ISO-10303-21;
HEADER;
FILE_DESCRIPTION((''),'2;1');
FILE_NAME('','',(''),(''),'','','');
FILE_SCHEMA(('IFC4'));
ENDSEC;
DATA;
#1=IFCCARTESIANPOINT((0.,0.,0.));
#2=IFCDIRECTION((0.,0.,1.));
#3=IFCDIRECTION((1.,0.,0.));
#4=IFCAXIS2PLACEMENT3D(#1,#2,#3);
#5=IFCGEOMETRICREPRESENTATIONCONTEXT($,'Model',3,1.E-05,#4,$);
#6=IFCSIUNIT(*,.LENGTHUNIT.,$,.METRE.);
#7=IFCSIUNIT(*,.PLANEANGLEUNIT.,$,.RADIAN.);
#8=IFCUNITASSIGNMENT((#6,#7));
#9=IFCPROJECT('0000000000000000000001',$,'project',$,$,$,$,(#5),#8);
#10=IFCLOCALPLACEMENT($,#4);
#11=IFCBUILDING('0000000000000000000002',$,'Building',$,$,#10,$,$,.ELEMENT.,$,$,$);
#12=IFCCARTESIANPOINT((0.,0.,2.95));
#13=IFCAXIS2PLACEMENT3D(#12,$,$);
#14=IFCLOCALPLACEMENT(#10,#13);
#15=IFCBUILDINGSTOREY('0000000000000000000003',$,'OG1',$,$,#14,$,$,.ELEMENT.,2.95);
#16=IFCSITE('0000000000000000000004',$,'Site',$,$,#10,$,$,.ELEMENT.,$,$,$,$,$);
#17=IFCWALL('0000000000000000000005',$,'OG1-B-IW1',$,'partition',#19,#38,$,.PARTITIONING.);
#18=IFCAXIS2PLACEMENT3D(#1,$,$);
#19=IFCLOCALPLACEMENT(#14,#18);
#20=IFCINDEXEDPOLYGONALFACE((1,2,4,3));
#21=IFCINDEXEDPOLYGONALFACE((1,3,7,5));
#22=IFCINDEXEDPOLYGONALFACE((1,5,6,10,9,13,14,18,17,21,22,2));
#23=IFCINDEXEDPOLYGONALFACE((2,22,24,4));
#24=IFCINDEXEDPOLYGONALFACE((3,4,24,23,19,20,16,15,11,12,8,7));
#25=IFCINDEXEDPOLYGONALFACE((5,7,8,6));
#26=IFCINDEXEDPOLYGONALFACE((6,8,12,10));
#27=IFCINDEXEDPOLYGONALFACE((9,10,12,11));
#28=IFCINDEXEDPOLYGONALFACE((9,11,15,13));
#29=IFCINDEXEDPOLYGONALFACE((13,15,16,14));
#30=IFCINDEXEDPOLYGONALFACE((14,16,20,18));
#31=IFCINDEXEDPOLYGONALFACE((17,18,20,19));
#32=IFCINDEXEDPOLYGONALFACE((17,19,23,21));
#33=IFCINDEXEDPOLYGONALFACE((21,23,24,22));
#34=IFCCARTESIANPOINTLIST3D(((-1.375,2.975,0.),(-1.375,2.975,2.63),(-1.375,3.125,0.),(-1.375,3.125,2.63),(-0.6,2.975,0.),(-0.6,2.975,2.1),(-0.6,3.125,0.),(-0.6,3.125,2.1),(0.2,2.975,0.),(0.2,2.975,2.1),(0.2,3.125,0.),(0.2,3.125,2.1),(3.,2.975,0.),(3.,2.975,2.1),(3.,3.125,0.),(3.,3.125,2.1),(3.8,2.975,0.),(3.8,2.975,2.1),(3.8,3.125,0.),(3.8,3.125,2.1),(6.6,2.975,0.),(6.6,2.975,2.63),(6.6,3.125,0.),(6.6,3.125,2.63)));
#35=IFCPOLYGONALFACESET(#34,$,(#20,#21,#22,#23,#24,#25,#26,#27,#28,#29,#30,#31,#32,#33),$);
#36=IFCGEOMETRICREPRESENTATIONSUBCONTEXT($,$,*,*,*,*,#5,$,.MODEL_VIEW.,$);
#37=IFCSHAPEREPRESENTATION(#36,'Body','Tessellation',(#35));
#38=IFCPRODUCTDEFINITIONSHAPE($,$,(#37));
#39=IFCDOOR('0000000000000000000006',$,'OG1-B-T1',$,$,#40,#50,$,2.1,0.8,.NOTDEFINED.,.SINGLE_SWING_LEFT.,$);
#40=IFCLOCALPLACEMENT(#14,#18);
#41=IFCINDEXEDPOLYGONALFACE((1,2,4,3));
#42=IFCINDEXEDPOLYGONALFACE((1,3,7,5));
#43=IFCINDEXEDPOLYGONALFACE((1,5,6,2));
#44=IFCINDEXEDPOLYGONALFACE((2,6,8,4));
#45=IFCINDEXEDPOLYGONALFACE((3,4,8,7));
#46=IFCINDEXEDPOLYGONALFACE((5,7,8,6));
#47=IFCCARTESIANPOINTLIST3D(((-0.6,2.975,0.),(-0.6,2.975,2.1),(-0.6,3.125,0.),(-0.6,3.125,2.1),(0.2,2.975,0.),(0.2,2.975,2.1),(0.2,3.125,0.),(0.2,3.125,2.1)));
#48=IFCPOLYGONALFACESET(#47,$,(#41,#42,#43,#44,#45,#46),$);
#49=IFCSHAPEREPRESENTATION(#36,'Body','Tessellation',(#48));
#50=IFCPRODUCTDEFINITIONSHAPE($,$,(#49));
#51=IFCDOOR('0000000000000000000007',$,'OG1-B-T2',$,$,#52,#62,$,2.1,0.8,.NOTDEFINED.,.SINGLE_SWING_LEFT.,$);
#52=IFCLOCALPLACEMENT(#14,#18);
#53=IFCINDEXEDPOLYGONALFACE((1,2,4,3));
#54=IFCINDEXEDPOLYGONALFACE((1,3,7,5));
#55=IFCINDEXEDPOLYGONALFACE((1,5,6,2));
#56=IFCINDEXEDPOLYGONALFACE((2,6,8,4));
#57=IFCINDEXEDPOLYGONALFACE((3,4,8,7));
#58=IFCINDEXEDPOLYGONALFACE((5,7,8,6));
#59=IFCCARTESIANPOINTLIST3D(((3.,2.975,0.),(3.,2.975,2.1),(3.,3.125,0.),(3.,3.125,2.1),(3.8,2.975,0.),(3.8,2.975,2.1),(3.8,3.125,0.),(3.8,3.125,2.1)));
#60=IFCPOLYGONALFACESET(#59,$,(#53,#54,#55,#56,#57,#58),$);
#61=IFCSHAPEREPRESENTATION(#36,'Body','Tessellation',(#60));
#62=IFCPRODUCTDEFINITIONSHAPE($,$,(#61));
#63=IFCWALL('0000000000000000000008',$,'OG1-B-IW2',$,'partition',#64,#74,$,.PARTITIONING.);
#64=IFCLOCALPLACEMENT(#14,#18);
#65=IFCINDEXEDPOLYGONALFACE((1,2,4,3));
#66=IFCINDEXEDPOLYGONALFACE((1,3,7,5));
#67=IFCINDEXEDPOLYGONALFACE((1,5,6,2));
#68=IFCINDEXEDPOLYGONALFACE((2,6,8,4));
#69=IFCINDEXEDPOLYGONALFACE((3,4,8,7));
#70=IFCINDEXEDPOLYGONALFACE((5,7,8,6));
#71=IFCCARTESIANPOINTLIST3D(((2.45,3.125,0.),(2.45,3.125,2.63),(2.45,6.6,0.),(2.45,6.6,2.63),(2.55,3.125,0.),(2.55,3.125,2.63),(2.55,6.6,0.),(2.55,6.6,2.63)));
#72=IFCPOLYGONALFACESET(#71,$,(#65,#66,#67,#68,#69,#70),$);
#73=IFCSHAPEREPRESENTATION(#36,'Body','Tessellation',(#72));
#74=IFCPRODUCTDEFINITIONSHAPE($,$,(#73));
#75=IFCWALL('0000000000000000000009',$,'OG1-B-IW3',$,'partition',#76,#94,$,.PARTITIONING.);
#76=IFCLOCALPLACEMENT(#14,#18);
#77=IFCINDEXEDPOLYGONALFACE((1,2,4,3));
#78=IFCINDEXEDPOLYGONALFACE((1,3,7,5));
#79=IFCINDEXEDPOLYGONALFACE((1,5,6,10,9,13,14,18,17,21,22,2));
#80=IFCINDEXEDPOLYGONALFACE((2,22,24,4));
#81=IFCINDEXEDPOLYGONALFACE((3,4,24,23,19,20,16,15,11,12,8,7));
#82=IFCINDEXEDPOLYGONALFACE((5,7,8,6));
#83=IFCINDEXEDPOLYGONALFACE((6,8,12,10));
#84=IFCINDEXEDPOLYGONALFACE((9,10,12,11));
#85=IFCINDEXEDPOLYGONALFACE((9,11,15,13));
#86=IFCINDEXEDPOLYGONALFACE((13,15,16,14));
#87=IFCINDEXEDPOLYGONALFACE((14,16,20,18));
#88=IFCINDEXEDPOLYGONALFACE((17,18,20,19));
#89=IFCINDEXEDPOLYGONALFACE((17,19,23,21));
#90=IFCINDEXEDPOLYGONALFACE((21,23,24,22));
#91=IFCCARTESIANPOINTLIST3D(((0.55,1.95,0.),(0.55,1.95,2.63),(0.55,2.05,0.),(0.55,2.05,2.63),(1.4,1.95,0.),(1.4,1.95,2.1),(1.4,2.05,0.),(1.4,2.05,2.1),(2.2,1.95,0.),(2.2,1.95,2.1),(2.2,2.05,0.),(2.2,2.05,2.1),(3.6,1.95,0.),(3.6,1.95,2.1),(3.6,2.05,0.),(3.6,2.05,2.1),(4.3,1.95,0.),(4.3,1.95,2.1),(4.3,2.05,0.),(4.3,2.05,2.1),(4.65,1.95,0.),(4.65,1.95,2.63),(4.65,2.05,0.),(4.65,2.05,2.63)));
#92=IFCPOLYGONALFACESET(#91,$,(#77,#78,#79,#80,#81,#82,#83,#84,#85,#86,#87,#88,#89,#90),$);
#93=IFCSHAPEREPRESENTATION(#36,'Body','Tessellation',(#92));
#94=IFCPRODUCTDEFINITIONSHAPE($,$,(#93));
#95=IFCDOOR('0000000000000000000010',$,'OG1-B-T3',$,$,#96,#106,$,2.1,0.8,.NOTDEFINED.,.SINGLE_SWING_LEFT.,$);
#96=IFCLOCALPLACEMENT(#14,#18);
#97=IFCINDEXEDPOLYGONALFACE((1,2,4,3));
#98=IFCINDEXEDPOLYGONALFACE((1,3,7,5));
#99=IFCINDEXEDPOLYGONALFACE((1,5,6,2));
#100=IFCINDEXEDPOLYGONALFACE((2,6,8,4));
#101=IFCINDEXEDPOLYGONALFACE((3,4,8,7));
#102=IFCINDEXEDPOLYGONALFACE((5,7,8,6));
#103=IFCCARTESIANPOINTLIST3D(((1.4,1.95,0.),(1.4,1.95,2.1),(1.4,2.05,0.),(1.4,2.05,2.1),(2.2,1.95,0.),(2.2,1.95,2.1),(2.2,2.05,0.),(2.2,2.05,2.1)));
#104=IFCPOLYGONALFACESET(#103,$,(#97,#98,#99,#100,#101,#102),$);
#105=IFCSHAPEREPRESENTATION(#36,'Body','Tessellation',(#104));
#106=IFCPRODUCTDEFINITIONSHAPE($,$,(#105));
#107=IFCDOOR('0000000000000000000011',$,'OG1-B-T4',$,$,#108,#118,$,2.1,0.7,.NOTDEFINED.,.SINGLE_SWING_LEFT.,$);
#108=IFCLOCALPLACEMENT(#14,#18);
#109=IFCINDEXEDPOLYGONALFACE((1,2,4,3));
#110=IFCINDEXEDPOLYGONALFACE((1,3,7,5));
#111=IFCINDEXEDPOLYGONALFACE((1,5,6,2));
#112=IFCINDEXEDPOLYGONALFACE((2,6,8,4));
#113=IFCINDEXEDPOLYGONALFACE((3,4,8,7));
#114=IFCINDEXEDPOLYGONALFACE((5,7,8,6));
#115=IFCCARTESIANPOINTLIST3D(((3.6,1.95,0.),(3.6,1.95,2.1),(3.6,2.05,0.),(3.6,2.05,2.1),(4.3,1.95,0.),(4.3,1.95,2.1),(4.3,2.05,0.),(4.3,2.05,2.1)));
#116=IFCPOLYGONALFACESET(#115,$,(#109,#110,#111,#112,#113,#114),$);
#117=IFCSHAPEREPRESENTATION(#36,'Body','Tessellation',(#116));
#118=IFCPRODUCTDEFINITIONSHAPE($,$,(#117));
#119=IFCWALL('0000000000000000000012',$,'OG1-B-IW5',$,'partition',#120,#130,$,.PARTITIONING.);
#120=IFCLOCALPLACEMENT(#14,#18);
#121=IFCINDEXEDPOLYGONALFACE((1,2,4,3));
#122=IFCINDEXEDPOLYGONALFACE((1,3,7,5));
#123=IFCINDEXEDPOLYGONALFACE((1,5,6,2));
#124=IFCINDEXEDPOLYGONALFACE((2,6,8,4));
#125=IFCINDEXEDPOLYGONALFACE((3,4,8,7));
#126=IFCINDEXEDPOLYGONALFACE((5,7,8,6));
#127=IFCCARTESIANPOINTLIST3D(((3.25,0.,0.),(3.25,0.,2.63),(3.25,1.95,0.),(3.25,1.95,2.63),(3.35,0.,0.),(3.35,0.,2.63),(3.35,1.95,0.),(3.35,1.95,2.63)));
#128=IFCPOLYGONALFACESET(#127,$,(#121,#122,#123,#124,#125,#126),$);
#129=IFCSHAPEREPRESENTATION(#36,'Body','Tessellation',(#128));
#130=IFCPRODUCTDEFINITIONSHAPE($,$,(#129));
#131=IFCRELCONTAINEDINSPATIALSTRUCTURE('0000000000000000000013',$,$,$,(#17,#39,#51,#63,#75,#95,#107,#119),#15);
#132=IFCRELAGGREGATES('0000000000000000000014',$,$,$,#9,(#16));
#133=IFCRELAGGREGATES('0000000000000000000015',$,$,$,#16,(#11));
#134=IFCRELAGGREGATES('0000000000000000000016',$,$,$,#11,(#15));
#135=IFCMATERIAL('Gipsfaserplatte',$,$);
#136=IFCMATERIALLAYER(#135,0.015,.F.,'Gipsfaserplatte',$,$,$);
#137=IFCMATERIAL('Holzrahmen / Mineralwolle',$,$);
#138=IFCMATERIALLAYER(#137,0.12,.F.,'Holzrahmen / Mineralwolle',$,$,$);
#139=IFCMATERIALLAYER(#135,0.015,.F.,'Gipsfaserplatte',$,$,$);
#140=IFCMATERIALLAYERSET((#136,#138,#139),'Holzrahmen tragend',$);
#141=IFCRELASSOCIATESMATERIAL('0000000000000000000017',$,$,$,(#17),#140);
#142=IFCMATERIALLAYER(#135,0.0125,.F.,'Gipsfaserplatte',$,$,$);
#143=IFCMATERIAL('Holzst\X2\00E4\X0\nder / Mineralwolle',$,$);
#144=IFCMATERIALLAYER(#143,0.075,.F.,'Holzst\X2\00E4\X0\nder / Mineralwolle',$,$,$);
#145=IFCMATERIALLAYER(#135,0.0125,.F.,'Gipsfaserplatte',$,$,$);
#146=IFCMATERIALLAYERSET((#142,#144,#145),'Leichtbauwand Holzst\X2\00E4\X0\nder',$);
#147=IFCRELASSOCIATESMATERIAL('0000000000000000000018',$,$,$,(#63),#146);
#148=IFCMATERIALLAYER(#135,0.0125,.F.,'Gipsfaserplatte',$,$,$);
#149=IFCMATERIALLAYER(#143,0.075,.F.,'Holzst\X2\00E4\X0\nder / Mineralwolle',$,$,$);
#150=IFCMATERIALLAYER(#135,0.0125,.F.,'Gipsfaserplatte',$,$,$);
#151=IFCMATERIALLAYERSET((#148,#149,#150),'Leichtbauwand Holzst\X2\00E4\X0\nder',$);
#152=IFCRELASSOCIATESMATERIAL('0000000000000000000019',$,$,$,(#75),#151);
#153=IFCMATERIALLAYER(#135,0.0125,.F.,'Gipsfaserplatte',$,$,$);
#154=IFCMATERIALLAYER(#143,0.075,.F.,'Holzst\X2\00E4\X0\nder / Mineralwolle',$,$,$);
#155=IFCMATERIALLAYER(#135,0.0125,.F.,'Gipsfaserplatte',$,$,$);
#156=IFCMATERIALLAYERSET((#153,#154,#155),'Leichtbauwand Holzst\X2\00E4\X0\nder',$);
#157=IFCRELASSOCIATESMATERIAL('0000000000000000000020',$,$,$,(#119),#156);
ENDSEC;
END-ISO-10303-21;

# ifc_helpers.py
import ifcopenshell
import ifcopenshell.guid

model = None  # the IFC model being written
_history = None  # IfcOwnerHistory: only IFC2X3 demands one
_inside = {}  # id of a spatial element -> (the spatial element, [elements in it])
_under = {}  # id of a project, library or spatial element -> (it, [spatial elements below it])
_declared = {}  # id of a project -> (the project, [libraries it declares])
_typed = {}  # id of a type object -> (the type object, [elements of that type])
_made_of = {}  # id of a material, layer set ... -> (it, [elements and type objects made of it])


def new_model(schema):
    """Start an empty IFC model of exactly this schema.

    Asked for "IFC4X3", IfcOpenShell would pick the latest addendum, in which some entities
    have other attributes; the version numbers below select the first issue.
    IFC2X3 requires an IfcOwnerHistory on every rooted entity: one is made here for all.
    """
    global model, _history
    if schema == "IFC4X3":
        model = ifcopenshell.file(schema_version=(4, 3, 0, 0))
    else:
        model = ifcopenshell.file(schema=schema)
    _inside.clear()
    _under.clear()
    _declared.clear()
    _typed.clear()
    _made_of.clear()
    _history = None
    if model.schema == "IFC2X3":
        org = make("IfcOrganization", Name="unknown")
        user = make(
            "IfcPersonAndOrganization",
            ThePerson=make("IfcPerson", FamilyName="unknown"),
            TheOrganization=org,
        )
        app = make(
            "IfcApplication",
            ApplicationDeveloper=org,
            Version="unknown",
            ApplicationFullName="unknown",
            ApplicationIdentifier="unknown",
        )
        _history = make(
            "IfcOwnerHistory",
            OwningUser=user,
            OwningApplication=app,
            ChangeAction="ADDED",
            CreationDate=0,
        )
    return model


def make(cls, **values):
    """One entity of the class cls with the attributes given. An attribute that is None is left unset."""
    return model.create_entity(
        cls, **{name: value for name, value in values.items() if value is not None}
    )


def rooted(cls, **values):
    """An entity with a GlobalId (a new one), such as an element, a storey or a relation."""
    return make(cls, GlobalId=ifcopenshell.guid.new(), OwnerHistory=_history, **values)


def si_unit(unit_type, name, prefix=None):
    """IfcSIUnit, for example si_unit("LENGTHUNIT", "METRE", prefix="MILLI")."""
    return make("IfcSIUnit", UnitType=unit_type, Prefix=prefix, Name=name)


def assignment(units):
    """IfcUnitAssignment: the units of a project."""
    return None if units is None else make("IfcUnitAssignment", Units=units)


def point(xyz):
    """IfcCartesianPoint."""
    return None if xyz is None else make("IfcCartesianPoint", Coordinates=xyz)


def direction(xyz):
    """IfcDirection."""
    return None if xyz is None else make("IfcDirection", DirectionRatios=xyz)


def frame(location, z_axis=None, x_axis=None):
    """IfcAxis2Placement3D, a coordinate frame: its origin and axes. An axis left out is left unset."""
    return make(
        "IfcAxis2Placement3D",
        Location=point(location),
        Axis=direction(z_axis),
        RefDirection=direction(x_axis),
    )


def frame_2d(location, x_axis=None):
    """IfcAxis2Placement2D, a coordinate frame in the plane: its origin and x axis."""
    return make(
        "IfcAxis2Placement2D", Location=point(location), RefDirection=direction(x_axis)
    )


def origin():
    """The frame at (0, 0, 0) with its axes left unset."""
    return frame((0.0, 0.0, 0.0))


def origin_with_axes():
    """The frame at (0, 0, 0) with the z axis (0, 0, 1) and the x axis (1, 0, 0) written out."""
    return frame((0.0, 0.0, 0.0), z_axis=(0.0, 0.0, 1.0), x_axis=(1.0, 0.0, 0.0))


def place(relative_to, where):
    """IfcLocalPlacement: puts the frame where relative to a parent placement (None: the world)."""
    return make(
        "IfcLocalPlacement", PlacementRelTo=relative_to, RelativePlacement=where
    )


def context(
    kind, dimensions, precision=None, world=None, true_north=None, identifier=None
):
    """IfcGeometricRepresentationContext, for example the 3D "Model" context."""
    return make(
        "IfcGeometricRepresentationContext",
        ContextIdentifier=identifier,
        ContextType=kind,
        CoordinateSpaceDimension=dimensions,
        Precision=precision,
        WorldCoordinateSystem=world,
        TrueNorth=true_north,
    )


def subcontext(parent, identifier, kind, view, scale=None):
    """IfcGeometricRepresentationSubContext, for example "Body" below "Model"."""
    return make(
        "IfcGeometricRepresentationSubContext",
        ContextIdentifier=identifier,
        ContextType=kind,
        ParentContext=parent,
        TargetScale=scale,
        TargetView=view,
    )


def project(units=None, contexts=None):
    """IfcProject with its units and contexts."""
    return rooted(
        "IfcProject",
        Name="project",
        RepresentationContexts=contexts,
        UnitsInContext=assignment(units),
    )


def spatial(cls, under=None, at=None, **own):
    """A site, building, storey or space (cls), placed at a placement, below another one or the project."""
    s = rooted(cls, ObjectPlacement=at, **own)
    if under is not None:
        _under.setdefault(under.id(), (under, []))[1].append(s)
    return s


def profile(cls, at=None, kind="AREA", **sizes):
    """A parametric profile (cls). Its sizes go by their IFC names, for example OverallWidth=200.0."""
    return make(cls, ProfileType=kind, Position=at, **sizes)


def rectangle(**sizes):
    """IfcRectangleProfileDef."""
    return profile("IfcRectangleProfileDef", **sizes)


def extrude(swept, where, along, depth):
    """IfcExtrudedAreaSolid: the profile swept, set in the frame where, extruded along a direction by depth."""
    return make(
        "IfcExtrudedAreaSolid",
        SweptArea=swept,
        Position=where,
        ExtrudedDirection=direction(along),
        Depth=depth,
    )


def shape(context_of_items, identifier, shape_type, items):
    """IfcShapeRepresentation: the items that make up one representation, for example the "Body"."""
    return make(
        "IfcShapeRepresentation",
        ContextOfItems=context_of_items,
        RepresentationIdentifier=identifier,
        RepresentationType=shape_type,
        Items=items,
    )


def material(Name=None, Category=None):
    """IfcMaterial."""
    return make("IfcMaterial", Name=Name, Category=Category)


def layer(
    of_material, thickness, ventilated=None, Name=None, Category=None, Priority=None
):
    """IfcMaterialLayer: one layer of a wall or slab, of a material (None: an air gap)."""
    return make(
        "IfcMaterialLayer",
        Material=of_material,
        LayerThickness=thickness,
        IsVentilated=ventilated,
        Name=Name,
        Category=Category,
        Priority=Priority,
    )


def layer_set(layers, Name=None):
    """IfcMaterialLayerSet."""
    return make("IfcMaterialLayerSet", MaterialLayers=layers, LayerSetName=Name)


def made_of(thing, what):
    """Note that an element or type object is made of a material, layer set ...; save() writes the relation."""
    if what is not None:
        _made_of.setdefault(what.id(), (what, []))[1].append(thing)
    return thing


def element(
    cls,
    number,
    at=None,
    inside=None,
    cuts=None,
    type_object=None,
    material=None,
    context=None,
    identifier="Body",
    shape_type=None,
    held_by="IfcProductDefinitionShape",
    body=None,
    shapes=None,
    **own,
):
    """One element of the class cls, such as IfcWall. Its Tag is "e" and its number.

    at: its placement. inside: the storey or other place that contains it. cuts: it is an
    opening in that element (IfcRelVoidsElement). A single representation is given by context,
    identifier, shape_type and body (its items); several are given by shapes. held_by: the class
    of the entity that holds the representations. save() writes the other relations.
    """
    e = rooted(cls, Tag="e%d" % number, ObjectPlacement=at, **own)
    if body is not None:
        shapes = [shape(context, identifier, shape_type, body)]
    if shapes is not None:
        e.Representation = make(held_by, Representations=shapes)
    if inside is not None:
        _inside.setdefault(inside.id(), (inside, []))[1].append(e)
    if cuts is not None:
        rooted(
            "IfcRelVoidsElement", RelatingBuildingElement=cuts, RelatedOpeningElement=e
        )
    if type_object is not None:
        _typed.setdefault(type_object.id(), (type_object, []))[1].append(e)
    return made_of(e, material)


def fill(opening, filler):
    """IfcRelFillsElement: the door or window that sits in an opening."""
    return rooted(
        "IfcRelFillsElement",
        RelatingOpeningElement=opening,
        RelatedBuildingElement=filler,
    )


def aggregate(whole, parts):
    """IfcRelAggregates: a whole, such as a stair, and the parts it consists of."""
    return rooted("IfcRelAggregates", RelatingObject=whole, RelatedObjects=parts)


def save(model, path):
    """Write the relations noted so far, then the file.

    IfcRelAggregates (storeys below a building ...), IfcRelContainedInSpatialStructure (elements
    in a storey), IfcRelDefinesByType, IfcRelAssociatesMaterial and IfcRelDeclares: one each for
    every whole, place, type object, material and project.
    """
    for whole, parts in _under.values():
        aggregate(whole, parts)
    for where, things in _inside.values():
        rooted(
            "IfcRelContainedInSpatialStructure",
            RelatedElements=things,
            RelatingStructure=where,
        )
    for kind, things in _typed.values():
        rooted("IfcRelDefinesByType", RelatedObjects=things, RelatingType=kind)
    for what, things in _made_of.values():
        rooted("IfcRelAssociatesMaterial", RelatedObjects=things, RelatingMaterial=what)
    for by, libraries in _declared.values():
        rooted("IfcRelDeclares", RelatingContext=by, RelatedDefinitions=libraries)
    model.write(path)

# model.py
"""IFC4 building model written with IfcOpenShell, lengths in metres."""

from ifc_helpers import new_model, si_unit, frame, frame_2d, origin, origin_with_axes, place, context, subcontext, project, spatial, rectangle, extrude, material, layer, layer_set, element, fill, save


model = new_model("IFC4")

# Units and contexts
model_context = context("Model", 3, precision=1e-05, world=origin_with_axes())
sub_context = subcontext(model_context, None, None, "MODEL_VIEW")
ifc_project = project(units=[si_unit("LENGTHUNIT", "METRE"), si_unit("PLANEANGLEUNIT", "RADIAN")], contexts=[model_context])

# Site, building, storey
placement = place(None, origin_with_axes())
site = spatial("IfcSite", under=ifc_project, at=placement, Name="Site", CompositionType="ELEMENT")
building = spatial("IfcBuilding", under=site, at=placement, Name="Building", CompositionType="ELEMENT")
storey_placement = place(placement, frame((0.0, 0.0, 2.95)))
storey = spatial("IfcBuildingStorey", under=building, at=storey_placement, Name="OG1", CompositionType="ELEMENT", Elevation=2.95)

# Shared definitions
ifc_material_1 = material(Name="Gipsfaserplatte")
ifc_material_2 = material(Name="Holzrahmen / Mineralwolle")

# Wall, openings, doors
ifc_layer_1 = layer(ifc_material_1, 0.015, ventilated=False, Name="Gipsfaserplatte")
ifc_layer_2 = layer(ifc_material_2, 0.12, ventilated=False, Name="Holzrahmen / Mineralwolle")
ifc_layer_3 = layer(ifc_material_1, 0.015, ventilated=False, Name="Gipsfaserplatte")
ifc_layer_set_1 = layer_set([ifc_layer_1, ifc_layer_2, ifc_layer_3], Name="Holzrahmen tragend")
wall_1_placement = place(storey_placement, frame((-1.375, 3.05, 0.0), z_axis=(0.0, 0.0, 1.0), x_axis=(1.0, 0.0, 0.0)))
wall_1 = element("IfcWall", 1, at=wall_1_placement, inside=storey, material=ifc_layer_set_1, Name="OG1-B-IW1", ObjectType="partition", PredefinedType="PARTITIONING", context=sub_context, shape_type="SweptSolid", body=[
    extrude(rectangle(XDim=7.975, YDim=0.15, at=frame_2d((3.9875, 0.0))), origin(), (0.0, 0.0, 1.0), 2.63),
])
opening_1_placement = place(wall_1_placement, frame((1.175, 0.125, 0.0), z_axis=(0.0, -1.0, 0.0), x_axis=(1.0, 0.0, 0.0)))
opening_1 = element("IfcOpeningElement", 2, at=opening_1_placement, cuts=wall_1, PredefinedType="OPENING", context=sub_context, shape_type="SweptSolid", body=[
    extrude(rectangle(XDim=0.8, YDim=2.1, at=frame_2d((0.0, 1.05))), origin(), (0.0, 0.0, 1.0), 0.25),
])
opening_2_placement = place(wall_1_placement, frame((4.775, 0.125, 0.0), z_axis=(0.0, -1.0, 0.0), x_axis=(1.0, 0.0, 0.0)))
opening_2 = element("IfcOpeningElement", 3, at=opening_2_placement, cuts=wall_1, PredefinedType="OPENING", context=sub_context, shape_type="SweptSolid", body=[
    extrude(rectangle(XDim=0.8, YDim=2.1, at=frame_2d((0.0, 1.05))), origin(), (0.0, 0.0, 1.0), 0.25),
])
door_1_placement = place(wall_1_placement, frame((1.175, 0.075, 0.0), z_axis=(0.0, -1.0, 0.0), x_axis=(1.0, 0.0, 0.0)))
door_1 = element("IfcDoor", 4, at=door_1_placement, inside=storey, Name="OG1-B-T1", OperationType="SINGLE_SWING_LEFT", OverallHeight=2.1, OverallWidth=0.8, PredefinedType="NOTDEFINED", context=sub_context, shape_type="SweptSolid", body=[
    extrude(rectangle(XDim=0.8, YDim=2.1, at=frame_2d((0.0, 1.05))), origin(), (0.0, 0.0, 1.0), 0.15),
])
fill(opening_1, door_1)
door_2_placement = place(wall_1_placement, frame((4.775, 0.075, 0.0), z_axis=(0.0, -1.0, 0.0), x_axis=(1.0, 0.0, 0.0)))
door_2 = element("IfcDoor", 5, at=door_2_placement, inside=storey, Name="OG1-B-T2", OperationType="SINGLE_SWING_LEFT", OverallHeight=2.1, OverallWidth=0.8, PredefinedType="NOTDEFINED", context=sub_context, shape_type="SweptSolid", body=[
    extrude(rectangle(XDim=0.8, YDim=2.1, at=frame_2d((0.0, 1.05))), origin(), (0.0, 0.0, 1.0), 0.15),
])
fill(opening_2, door_2)

# Wall
ifc_layer_4 = layer(ifc_material_1, 0.0125, ventilated=False, Name="Gipsfaserplatte")
ifc_material_3 = material(Name="Holzständer / Mineralwolle")
ifc_layer_5 = layer(ifc_material_3, 0.075, ventilated=False, Name="Holzständer / Mineralwolle")
ifc_layer_6 = layer(ifc_material_1, 0.0125, ventilated=False, Name="Gipsfaserplatte")
ifc_layer_set_2 = layer_set([ifc_layer_4, ifc_layer_5, ifc_layer_6], Name="Leichtbauwand Holzständer")
wall_2_placement = place(storey_placement, frame((2.5, 3.125, 0.0), z_axis=(0.0, 0.0, 1.0), x_axis=(0.0, 1.0, 0.0)))
element("IfcWall", 6, at=wall_2_placement, inside=storey, material=ifc_layer_set_2, Name="OG1-B-IW2", ObjectType="partition", PredefinedType="PARTITIONING", context=sub_context, shape_type="SweptSolid", body=[
    extrude(rectangle(XDim=3.475, YDim=0.1, at=frame_2d((1.7375, 0.0))), origin(), (0.0, 0.0, 1.0), 2.63),
])

# Wall, openings, doors
ifc_layer_7 = layer(ifc_material_1, 0.0125, ventilated=False, Name="Gipsfaserplatte")
ifc_layer_8 = layer(ifc_material_3, 0.075, ventilated=False, Name="Holzständer / Mineralwolle")
ifc_layer_9 = layer(ifc_material_1, 0.0125, ventilated=False, Name="Gipsfaserplatte")
ifc_layer_set_3 = layer_set([ifc_layer_7, ifc_layer_8, ifc_layer_9], Name="Leichtbauwand Holzständer")
wall_3_placement = place(storey_placement, frame((0.55, 2.0, 0.0), z_axis=(0.0, 0.0, 1.0), x_axis=(1.0, 0.0, 0.0)))
wall_3 = element("IfcWall", 7, at=wall_3_placement, inside=storey, material=ifc_layer_set_3, Name="OG1-B-IW3", ObjectType="partition", PredefinedType="PARTITIONING", context=sub_context, shape_type="SweptSolid", body=[
    extrude(rectangle(XDim=4.1, YDim=0.1, at=frame_2d((2.05, 0.0))), origin(), (0.0, 0.0, 1.0), 2.63),
])
opening_3_placement = place(wall_3_placement, frame((1.25, 0.1, 0.0), z_axis=(0.0, -1.0, 0.0), x_axis=(1.0, 0.0, 0.0)))
opening_3 = element("IfcOpeningElement", 8, at=opening_3_placement, cuts=wall_3, PredefinedType="OPENING", context=sub_context, shape_type="SweptSolid", body=[
    extrude(rectangle(XDim=0.8, YDim=2.1, at=frame_2d((0.0, 1.05))), origin(), (0.0, 0.0, 1.0), 0.2),
])
opening_4_placement = place(wall_3_placement, frame((3.4, 0.1, 0.0), z_axis=(0.0, -1.0, 0.0), x_axis=(1.0, 0.0, 0.0)))
opening_4 = element("IfcOpeningElement", 9, at=opening_4_placement, cuts=wall_3, PredefinedType="OPENING", context=sub_context, shape_type="SweptSolid", body=[
    extrude(rectangle(XDim=0.7, YDim=2.1, at=frame_2d((0.0, 1.05))), origin(), (0.0, 0.0, 1.0), 0.2),
])
door_3_placement = place(wall_3_placement, frame((1.25, 0.05, 0.0), z_axis=(0.0, -1.0, 0.0), x_axis=(1.0, 0.0, 0.0)))
door_3 = element("IfcDoor", 10, at=door_3_placement, inside=storey, Name="OG1-B-T3", OperationType="SINGLE_SWING_LEFT", OverallHeight=2.1, OverallWidth=0.8, PredefinedType="NOTDEFINED", context=sub_context, shape_type="SweptSolid", body=[
    extrude(rectangle(XDim=0.8, YDim=2.1, at=frame_2d((0.0, 1.05))), origin(), (0.0, 0.0, 1.0), 0.1),
])
fill(opening_3, door_3)
door_4_placement = place(wall_3_placement, frame((3.4, 0.05, 0.0), z_axis=(0.0, -1.0, 0.0), x_axis=(1.0, 0.0, 0.0)))
door_4 = element("IfcDoor", 11, at=door_4_placement, inside=storey, Name="OG1-B-T4", OperationType="SINGLE_SWING_LEFT", OverallHeight=2.1, OverallWidth=0.7, PredefinedType="NOTDEFINED", context=sub_context, shape_type="SweptSolid", body=[
    extrude(rectangle(XDim=0.7, YDim=2.1, at=frame_2d((0.0, 1.05))), origin(), (0.0, 0.0, 1.0), 0.1),
])
fill(opening_4, door_4)

# Wall
ifc_layer_10 = layer(ifc_material_1, 0.0125, ventilated=False, Name="Gipsfaserplatte")
ifc_layer_11 = layer(ifc_material_3, 0.075, ventilated=False, Name="Holzständer / Mineralwolle")
ifc_layer_12 = layer(ifc_material_1, 0.0125, ventilated=False, Name="Gipsfaserplatte")
ifc_layer_set_4 = layer_set([ifc_layer_10, ifc_layer_11, ifc_layer_12], Name="Leichtbauwand Holzständer")
wall_4_placement = place(storey_placement, frame((3.3, 0.0, 0.0), z_axis=(0.0, 0.0, 1.0), x_axis=(0.0, 1.0, 0.0)))
element("IfcWall", 12, at=wall_4_placement, inside=storey, material=ifc_layer_set_4, Name="OG1-B-IW5", ObjectType="partition", PredefinedType="PARTITIONING", context=sub_context, shape_type="SweptSolid", body=[
    extrude(rectangle(XDim=1.95, YDim=0.1, at=frame_2d((0.975, 0.0))), origin(), (0.0, 0.0, 1.0), 2.63),
])

save(model, "model.ifc")
